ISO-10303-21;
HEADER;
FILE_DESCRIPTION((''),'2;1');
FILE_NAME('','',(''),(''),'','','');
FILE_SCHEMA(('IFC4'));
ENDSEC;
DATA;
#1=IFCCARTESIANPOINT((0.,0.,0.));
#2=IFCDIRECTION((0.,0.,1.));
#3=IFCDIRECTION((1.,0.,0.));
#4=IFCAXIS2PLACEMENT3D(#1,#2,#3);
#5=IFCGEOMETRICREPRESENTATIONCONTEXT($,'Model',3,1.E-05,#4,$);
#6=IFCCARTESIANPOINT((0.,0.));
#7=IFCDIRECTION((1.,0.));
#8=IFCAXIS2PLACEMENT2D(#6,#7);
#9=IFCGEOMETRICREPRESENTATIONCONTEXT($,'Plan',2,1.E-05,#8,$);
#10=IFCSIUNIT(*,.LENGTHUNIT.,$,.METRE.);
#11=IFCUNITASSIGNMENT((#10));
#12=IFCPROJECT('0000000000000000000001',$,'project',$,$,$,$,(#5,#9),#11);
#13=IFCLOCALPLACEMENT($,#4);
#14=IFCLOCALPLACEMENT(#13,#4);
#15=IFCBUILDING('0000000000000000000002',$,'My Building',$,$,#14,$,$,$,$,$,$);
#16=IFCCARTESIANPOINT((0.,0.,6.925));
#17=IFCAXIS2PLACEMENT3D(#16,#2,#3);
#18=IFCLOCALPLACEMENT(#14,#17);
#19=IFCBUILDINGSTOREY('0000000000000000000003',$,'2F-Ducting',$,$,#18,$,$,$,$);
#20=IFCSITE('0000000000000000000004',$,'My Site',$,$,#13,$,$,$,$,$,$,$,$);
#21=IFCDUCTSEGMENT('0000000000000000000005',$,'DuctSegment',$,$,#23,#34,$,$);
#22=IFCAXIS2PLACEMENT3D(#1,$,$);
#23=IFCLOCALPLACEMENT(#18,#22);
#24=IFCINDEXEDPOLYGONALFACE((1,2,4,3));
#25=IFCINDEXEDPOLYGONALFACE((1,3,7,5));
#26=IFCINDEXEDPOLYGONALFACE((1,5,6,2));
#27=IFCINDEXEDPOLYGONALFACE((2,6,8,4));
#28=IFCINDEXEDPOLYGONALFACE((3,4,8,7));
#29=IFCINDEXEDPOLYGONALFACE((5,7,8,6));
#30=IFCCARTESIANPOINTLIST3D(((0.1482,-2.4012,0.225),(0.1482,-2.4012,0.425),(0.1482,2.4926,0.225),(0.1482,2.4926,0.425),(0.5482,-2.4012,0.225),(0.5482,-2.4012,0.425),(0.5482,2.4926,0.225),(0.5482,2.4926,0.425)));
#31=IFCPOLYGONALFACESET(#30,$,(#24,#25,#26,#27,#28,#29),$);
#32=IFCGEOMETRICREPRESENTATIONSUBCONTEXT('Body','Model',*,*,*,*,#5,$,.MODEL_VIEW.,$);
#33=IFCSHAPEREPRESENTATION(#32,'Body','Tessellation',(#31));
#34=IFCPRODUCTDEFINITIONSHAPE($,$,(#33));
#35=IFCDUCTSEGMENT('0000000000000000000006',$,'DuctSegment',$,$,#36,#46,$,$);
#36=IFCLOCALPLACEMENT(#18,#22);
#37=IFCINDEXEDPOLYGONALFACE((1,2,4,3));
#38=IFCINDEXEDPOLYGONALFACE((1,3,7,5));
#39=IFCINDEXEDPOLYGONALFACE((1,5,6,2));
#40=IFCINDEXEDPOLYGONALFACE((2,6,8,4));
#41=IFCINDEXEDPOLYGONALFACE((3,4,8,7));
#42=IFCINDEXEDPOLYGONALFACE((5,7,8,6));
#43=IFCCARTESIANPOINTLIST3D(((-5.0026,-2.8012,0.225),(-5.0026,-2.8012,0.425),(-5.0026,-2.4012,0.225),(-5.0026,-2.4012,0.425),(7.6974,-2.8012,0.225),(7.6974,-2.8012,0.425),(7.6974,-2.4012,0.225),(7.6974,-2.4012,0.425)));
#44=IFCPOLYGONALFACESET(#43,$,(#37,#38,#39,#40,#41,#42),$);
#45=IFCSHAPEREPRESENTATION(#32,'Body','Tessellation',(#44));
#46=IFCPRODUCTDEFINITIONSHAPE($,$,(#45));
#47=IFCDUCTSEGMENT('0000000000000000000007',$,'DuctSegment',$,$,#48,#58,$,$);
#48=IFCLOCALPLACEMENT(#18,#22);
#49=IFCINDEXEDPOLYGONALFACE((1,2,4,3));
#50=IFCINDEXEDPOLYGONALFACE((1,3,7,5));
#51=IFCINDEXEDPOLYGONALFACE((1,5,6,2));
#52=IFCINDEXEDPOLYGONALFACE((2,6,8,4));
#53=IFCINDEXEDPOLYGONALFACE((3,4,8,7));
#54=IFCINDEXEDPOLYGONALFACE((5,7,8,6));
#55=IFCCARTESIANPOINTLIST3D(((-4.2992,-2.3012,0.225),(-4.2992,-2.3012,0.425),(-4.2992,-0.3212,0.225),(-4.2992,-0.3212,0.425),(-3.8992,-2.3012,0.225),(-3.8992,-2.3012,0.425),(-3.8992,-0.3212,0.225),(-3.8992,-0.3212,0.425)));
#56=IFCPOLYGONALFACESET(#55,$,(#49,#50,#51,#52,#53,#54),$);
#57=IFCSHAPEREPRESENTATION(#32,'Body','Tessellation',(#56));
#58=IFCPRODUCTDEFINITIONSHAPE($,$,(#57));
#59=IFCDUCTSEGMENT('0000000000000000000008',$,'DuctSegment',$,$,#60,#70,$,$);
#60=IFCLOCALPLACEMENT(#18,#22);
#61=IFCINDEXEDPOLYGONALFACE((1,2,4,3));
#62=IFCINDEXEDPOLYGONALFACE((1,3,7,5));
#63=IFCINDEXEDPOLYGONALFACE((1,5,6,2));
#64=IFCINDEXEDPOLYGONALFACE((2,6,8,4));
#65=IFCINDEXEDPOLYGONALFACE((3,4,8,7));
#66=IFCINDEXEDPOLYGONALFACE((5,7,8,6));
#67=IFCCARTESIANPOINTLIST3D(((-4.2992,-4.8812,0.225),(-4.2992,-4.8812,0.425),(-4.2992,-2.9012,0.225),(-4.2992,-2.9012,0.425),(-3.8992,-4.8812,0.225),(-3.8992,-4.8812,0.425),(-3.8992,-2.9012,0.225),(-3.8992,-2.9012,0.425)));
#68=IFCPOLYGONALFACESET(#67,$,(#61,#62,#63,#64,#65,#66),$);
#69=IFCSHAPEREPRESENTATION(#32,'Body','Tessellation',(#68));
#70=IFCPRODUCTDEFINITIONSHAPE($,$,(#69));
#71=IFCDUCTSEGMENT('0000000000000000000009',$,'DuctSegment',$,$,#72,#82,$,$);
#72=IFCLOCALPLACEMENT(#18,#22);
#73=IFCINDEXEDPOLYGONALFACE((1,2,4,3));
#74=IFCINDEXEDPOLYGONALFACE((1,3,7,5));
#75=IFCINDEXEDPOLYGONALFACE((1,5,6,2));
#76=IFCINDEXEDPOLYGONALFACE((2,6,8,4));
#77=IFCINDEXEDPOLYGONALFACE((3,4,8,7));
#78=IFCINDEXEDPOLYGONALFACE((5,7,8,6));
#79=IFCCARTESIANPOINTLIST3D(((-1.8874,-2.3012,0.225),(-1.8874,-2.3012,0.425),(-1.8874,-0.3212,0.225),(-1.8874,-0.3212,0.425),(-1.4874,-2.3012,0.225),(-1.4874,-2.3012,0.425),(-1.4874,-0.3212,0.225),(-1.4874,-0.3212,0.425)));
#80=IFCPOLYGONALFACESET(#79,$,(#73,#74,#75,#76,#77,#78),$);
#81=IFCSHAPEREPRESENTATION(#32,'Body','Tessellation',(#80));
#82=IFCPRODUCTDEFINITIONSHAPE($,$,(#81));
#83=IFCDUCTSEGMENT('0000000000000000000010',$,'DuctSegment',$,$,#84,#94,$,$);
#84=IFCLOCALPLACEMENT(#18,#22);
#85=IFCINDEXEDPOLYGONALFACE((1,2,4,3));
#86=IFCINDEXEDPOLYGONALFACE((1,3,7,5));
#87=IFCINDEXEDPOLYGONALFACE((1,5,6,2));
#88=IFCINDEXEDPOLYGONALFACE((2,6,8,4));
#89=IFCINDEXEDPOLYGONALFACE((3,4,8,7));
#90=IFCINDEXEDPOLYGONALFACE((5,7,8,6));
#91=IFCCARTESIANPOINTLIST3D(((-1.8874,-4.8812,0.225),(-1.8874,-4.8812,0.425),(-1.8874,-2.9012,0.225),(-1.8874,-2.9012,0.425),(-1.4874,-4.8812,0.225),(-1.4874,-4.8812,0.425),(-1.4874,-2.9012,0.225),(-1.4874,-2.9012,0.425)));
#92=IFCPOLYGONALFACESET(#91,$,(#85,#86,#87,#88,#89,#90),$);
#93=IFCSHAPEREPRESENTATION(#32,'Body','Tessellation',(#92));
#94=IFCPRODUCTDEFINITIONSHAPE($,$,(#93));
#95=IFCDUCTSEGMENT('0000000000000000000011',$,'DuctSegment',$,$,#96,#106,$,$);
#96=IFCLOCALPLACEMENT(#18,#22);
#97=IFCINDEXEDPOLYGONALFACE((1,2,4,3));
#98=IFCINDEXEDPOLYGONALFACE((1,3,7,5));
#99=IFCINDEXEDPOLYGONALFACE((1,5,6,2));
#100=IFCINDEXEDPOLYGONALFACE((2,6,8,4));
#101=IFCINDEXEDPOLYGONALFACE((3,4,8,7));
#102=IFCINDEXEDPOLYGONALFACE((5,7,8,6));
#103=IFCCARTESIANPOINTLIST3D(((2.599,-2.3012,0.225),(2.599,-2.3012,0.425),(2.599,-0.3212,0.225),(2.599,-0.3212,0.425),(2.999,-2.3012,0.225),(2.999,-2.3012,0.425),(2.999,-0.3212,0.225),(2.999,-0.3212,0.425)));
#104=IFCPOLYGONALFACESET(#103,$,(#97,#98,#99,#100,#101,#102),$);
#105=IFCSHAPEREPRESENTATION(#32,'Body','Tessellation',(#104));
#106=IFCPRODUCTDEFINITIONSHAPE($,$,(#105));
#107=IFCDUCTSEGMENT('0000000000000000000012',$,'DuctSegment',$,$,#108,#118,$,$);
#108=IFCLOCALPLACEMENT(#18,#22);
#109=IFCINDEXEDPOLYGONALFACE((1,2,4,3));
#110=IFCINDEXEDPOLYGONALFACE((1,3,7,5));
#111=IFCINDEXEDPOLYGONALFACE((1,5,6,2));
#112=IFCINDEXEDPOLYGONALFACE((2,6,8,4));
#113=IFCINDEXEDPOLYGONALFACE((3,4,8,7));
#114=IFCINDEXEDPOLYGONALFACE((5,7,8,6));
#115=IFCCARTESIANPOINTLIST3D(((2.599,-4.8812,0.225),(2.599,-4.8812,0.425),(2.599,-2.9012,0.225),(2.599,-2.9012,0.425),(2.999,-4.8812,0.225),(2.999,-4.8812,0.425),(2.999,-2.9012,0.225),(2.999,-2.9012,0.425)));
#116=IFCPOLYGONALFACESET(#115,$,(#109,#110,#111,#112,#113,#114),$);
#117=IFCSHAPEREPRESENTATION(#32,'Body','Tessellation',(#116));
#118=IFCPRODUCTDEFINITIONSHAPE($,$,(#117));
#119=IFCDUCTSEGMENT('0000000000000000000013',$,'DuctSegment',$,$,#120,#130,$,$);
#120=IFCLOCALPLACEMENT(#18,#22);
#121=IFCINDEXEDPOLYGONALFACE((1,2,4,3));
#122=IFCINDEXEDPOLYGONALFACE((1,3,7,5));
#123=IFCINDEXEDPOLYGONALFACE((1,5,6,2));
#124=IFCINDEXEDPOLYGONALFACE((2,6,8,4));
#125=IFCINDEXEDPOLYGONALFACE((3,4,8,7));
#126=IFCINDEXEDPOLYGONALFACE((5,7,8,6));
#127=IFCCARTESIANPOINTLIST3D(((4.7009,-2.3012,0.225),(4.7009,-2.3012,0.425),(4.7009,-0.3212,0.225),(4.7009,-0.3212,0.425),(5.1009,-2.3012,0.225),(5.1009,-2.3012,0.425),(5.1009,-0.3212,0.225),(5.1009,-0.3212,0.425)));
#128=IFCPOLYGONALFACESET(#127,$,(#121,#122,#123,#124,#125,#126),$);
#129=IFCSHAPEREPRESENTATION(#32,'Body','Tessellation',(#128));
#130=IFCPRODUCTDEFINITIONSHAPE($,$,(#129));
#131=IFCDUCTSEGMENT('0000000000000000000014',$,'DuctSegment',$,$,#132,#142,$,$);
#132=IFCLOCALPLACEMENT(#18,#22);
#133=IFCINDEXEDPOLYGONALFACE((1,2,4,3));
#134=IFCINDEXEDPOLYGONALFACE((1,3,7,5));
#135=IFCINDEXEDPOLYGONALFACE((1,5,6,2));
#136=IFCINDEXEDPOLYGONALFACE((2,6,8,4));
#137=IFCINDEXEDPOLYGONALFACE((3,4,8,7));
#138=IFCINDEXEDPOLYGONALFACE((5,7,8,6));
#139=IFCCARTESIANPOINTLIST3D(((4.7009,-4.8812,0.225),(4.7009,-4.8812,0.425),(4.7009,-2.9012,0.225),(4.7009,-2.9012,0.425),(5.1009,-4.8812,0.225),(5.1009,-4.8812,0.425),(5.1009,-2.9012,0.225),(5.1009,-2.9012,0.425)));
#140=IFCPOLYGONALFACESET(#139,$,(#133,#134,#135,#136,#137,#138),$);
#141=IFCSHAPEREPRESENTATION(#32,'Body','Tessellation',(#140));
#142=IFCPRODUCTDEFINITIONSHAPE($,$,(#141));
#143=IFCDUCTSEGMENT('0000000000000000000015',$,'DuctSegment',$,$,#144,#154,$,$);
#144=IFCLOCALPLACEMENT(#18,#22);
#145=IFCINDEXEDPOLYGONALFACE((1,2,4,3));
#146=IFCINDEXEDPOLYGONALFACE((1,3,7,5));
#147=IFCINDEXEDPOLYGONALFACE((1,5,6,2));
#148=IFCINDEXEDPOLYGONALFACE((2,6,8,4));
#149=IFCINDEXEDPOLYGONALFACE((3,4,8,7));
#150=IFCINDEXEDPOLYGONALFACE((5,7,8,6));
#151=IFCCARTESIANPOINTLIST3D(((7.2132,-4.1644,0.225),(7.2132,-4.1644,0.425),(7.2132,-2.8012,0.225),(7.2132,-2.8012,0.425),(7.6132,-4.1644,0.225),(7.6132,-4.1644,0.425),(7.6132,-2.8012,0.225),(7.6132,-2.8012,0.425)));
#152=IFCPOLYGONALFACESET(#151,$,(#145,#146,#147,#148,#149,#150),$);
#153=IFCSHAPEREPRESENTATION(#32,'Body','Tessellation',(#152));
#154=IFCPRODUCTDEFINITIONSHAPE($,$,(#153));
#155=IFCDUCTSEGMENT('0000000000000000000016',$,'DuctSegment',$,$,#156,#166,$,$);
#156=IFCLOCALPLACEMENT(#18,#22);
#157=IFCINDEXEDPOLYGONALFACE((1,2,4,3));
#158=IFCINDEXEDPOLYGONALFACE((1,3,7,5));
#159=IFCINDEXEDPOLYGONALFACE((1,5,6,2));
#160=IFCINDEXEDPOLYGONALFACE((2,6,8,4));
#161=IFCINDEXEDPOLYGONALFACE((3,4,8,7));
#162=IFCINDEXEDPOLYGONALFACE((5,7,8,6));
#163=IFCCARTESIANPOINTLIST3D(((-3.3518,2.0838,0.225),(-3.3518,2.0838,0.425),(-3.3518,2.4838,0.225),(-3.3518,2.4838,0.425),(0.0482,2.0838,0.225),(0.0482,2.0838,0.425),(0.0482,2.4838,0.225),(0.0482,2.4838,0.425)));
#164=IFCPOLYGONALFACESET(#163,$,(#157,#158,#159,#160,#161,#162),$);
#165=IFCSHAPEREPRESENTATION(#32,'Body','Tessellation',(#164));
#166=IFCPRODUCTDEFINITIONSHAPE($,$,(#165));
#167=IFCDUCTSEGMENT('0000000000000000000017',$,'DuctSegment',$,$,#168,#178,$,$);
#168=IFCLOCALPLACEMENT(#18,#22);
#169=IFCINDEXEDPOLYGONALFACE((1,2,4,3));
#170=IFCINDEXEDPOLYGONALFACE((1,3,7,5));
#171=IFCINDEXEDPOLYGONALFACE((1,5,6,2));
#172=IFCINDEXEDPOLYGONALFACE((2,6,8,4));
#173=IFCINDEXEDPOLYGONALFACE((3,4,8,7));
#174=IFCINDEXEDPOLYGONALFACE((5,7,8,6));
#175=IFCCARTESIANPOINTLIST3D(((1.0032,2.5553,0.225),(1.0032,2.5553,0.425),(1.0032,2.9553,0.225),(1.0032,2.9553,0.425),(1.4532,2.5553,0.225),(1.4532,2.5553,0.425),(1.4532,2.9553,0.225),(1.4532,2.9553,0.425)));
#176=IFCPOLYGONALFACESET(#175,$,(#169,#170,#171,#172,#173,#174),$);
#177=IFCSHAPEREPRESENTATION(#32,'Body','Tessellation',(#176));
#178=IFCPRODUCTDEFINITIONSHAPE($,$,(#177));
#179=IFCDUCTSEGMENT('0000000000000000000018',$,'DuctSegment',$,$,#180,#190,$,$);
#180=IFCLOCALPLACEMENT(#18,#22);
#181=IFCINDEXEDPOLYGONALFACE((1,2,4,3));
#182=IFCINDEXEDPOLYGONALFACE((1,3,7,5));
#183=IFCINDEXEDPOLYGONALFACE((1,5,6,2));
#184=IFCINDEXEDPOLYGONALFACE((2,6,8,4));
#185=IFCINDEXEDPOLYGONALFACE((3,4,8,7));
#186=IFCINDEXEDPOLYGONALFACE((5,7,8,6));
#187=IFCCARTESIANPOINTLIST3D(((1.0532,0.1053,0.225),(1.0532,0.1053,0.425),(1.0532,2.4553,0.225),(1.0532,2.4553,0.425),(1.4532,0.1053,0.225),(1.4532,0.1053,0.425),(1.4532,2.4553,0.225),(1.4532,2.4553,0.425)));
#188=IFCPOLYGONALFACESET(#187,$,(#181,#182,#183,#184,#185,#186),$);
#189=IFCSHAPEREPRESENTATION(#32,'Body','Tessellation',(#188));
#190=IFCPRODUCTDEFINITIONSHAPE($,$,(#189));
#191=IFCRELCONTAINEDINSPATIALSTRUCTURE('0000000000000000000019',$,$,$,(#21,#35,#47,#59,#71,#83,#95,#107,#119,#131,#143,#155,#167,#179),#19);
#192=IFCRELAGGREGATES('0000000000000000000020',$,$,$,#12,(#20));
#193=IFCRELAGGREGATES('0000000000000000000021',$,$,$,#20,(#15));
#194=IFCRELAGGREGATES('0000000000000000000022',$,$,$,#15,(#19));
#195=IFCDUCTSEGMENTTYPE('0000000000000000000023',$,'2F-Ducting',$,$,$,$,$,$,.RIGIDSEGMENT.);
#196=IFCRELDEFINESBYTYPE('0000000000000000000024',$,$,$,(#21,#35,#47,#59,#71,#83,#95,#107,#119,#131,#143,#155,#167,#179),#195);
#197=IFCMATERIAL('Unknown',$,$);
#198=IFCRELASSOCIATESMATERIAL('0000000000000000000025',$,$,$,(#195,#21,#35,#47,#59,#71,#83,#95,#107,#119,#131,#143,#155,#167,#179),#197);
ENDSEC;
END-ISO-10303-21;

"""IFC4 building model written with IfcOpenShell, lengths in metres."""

from ifc_helpers import new_model, si_unit, frame, origin_with_axes, origin_2d_with_axis, place, context, subcontext, project, spatial, rectangle, extrude, material, material_profile, profile_set, profile_usage, type_object, element, save


model = new_model("IFC4")

# Units and contexts
model_context = context("Model", 3, precision=1e-05, world=origin_with_axes())
plan_context = context("Plan", 2, precision=1e-05, world=origin_2d_with_axis())
body_context = subcontext(model_context, "Body", "Model", "MODEL_VIEW")
ifc_project = project(units=[si_unit("LENGTHUNIT", "METRE")], contexts=[model_context, plan_context])

# Site, building, storey
site_placement = place(None, origin_with_axes())
site = spatial("IfcSite", under=ifc_project, at=site_placement, Name="My Site")
building_placement = place(site_placement, origin_with_axes())
building = spatial("IfcBuilding", under=site, at=building_placement, Name="My Building")
storey_placement = place(building_placement, frame((0.0, 0.0, 6.925), z_axis=(0.0, 0.0, 1.0), x_axis=(1.0, 0.0, 0.0)))
storey = spatial("IfcBuildingStorey", under=building, at=storey_placement, Name="2F-Ducting")

# Duct segments
ifc_material = material(Name="Unknown")
ifc_material_profile_1 = material_profile(ifc_material, rectangle(XDim=0.4, YDim=0.2))
ifc_profile_set_1 = profile_set([ifc_material_profile_1])
ifc_profile_usage_1 = profile_usage(ifc_profile_set_1, cardinal=5)
duct_segment_type = type_object("IfcDuctSegmentType", Name="2F-Ducting", PredefinedType="RIGIDSEGMENT", material=ifc_profile_set_1)
duct_segment_1_placement = place(storey_placement, frame((0.3482, 2.4926, 0.325), z_axis=(0.0, -1.0, 0.0), x_axis=(1.0, 0.0, 0.0)))
element("IfcDuctSegment", 1, at=duct_segment_1_placement, inside=storey, type_object=duct_segment_type, material=ifc_profile_usage_1, Name="DuctSegment", context=body_context, shape_type="SweptSolid", body=[
    extrude(rectangle(XDim=0.4, YDim=0.2), origin_with_axes(), (0.0, 0.0, 1.0), 4.8939),
])
ifc_profile_usage_2 = profile_usage(ifc_profile_set_1, cardinal=5)
duct_segment_2_placement = place(storey_placement, frame((-5.0026, -2.6012, 0.325), z_axis=(1.0, 0.0, 0.0), x_axis=(0.0, 1.0, 0.0)))
element("IfcDuctSegment", 2, at=duct_segment_2_placement, inside=storey, type_object=duct_segment_type, material=ifc_profile_usage_2, Name="DuctSegment", context=body_context, shape_type="SweptSolid", body=[
    extrude(rectangle(XDim=0.4, YDim=0.2), origin_with_axes(), (0.0, 0.0, 1.0), 12.7),
])
ifc_profile_usage_3 = profile_usage(ifc_profile_set_1, cardinal=5)
duct_segment_3_placement = place(storey_placement, frame((-4.0992, -2.3012, 0.325), z_axis=(0.0, 1.0, 0.0), x_axis=(-1.0, 0.0, 0.0)))
element("IfcDuctSegment", 3, at=duct_segment_3_placement, inside=storey, type_object=duct_segment_type, material=ifc_profile_usage_3, Name="DuctSegment", context=body_context, shape_type="SweptSolid", body=[
    extrude(rectangle(XDim=0.4, YDim=0.2), origin_with_axes(), (0.0, 0.0, 1.0), 1.98),
])
ifc_profile_usage_4 = profile_usage(ifc_profile_set_1, cardinal=5)
duct_segment_4_placement = place(storey_placement, frame((-4.0992, -4.8812, 0.325), z_axis=(0.0, 1.0, 0.0), x_axis=(-1.0, 0.0, 0.0)))
element("IfcDuctSegment", 4, at=duct_segment_4_placement, inside=storey, type_object=duct_segment_type, material=ifc_profile_usage_4, Name="DuctSegment", context=body_context, shape_type="SweptSolid", body=[
    extrude(rectangle(XDim=0.4, YDim=0.2), origin_with_axes(), (0.0, 0.0, 1.0), 1.98),
])
ifc_profile_usage_5 = profile_usage(ifc_profile_set_1, cardinal=5)
duct_segment_5_placement = place(storey_placement, frame((-1.6874, -2.3012, 0.325), z_axis=(0.0, 1.0, 0.0), x_axis=(-1.0, 0.0, 0.0)))
element("IfcDuctSegment", 5, at=duct_segment_5_placement, inside=storey, type_object=duct_segment_type, material=ifc_profile_usage_5, Name="DuctSegment", context=body_context, shape_type="SweptSolid", body=[
    extrude(rectangle(XDim=0.4, YDim=0.2), origin_with_axes(), (0.0, 0.0, 1.0), 1.98),
])
ifc_profile_usage_6 = profile_usage(ifc_profile_set_1, cardinal=5)
duct_segment_6_placement = place(storey_placement, frame((-1.6874, -4.8812, 0.325), z_axis=(0.0, 1.0, 0.0), x_axis=(-1.0, 0.0, 0.0)))
element("IfcDuctSegment", 6, at=duct_segment_6_placement, inside=storey, type_object=duct_segment_type, material=ifc_profile_usage_6, Name="DuctSegment", context=body_context, shape_type="SweptSolid", body=[
    extrude(rectangle(XDim=0.4, YDim=0.2), origin_with_axes(), (0.0, 0.0, 1.0), 1.98),
])
ifc_profile_usage_7 = profile_usage(ifc_profile_set_1, cardinal=5)
duct_segment_7_placement = place(storey_placement, frame((2.799, -2.3012, 0.325), z_axis=(0.0, 1.0, 0.0), x_axis=(-1.0, 0.0, 0.0)))
element("IfcDuctSegment", 7, at=duct_segment_7_placement, inside=storey, type_object=duct_segment_type, material=ifc_profile_usage_7, Name="DuctSegment", context=body_context, shape_type="SweptSolid", body=[
    extrude(rectangle(XDim=0.4, YDim=0.2), origin_with_axes(), (0.0, 0.0, 1.0), 1.98),
])
ifc_profile_usage_8 = profile_usage(ifc_profile_set_1, cardinal=5)
duct_segment_8_placement = place(storey_placement, frame((2.799, -4.8812, 0.325), z_axis=(0.0, 1.0, 0.0), x_axis=(-1.0, 0.0, 0.0)))
element("IfcDuctSegment", 8, at=duct_segment_8_placement, inside=storey, type_object=duct_segment_type, material=ifc_profile_usage_8, Name="DuctSegment", context=body_context, shape_type="SweptSolid", body=[
    extrude(rectangle(XDim=0.4, YDim=0.2), origin_with_axes(), (0.0, 0.0, 1.0), 1.98),
])
ifc_profile_usage_9 = profile_usage(ifc_profile_set_1, cardinal=5)
duct_segment_9_placement = place(storey_placement, frame((4.9009, -2.3012, 0.325), z_axis=(0.0, 1.0, 0.0), x_axis=(-1.0, 0.0, 0.0)))
element("IfcDuctSegment", 9, at=duct_segment_9_placement, inside=storey, type_object=duct_segment_type, material=ifc_profile_usage_9, Name="DuctSegment", context=body_context, shape_type="SweptSolid", body=[
    extrude(rectangle(XDim=0.4, YDim=0.2), origin_with_axes(), (0.0, 0.0, 1.0), 1.98),
])
ifc_profile_usage_10 = profile_usage(ifc_profile_set_1, cardinal=5)
duct_segment_10_placement = place(storey_placement, frame((4.9009, -4.8812, 0.325), z_axis=(0.0, 1.0, 0.0), x_axis=(-1.0, 0.0, 0.0)))
element("IfcDuctSegment", 10, at=duct_segment_10_placement, inside=storey, type_object=duct_segment_type, material=ifc_profile_usage_10, Name="DuctSegment", context=body_context, shape_type="SweptSolid", body=[
    extrude(rectangle(XDim=0.4, YDim=0.2), origin_with_axes(), (0.0, 0.0, 1.0), 1.98),
])
ifc_profile_usage_11 = profile_usage(ifc_profile_set_1, cardinal=5)
duct_segment_11_placement = place(storey_placement, frame((7.4132, -2.8012, 0.325), z_axis=(0.0, -1.0, 0.0), x_axis=(1.0, 0.0, 0.0)))
element("IfcDuctSegment", 11, at=duct_segment_11_placement, inside=storey, type_object=duct_segment_type, material=ifc_profile_usage_11, Name="DuctSegment", context=body_context, shape_type="SweptSolid", body=[
    extrude(rectangle(XDim=0.4, YDim=0.2), origin_with_axes(), (0.0, 0.0, 1.0), 1.3632),
])
ifc_profile_usage_12 = profile_usage(ifc_profile_set_1, cardinal=5)
duct_segment_12_placement = place(storey_placement, frame((0.0482, 2.2838, 0.325), z_axis=(-1.0, 0.0, 0.0), x_axis=(0.0, -1.0, 0.0)))
element("IfcDuctSegment", 12, at=duct_segment_12_placement, inside=storey, type_object=duct_segment_type, material=ifc_profile_usage_12, Name="DuctSegment", context=body_context, shape_type="SweptSolid", body=[
    extrude(rectangle(XDim=0.4, YDim=0.2), origin_with_axes(), (0.0, 0.0, 1.0), 3.4),
])
ifc_profile_usage_13 = profile_usage(ifc_profile_set_1, cardinal=5)
duct_segment_13_placement = place(storey_placement, frame((1.0032, 2.7553, 0.325), z_axis=(1.0, 0.0, 0.0), x_axis=(0.0, 1.0, 0.0)))
element("IfcDuctSegment", 13, at=duct_segment_13_placement, inside=storey, type_object=duct_segment_type, material=ifc_profile_usage_13, Name="DuctSegment", context=body_context, shape_type="SweptSolid", body=[
    extrude(rectangle(XDim=0.4, YDim=0.2), origin_with_axes(), (0.0, 0.0, 1.0), 0.45),
])
ifc_profile_usage_14 = profile_usage(ifc_profile_set_1, cardinal=5)
duct_segment_14_placement = place(storey_placement, frame((1.2532, 2.4553, 0.325), z_axis=(0.0, -1.0, 0.0), x_axis=(1.0, 0.0, 0.0)))
element("IfcDuctSegment", 14, at=duct_segment_14_placement, inside=storey, type_object=duct_segment_type, material=ifc_profile_usage_14, Name="DuctSegment", context=body_context, shape_type="SweptSolid", body=[
    extrude(rectangle(XDim=0.4, YDim=0.2), origin_with_axes(), (0.0, 0.0, 1.0), 2.35),
])

save(model, "model.ifc")
